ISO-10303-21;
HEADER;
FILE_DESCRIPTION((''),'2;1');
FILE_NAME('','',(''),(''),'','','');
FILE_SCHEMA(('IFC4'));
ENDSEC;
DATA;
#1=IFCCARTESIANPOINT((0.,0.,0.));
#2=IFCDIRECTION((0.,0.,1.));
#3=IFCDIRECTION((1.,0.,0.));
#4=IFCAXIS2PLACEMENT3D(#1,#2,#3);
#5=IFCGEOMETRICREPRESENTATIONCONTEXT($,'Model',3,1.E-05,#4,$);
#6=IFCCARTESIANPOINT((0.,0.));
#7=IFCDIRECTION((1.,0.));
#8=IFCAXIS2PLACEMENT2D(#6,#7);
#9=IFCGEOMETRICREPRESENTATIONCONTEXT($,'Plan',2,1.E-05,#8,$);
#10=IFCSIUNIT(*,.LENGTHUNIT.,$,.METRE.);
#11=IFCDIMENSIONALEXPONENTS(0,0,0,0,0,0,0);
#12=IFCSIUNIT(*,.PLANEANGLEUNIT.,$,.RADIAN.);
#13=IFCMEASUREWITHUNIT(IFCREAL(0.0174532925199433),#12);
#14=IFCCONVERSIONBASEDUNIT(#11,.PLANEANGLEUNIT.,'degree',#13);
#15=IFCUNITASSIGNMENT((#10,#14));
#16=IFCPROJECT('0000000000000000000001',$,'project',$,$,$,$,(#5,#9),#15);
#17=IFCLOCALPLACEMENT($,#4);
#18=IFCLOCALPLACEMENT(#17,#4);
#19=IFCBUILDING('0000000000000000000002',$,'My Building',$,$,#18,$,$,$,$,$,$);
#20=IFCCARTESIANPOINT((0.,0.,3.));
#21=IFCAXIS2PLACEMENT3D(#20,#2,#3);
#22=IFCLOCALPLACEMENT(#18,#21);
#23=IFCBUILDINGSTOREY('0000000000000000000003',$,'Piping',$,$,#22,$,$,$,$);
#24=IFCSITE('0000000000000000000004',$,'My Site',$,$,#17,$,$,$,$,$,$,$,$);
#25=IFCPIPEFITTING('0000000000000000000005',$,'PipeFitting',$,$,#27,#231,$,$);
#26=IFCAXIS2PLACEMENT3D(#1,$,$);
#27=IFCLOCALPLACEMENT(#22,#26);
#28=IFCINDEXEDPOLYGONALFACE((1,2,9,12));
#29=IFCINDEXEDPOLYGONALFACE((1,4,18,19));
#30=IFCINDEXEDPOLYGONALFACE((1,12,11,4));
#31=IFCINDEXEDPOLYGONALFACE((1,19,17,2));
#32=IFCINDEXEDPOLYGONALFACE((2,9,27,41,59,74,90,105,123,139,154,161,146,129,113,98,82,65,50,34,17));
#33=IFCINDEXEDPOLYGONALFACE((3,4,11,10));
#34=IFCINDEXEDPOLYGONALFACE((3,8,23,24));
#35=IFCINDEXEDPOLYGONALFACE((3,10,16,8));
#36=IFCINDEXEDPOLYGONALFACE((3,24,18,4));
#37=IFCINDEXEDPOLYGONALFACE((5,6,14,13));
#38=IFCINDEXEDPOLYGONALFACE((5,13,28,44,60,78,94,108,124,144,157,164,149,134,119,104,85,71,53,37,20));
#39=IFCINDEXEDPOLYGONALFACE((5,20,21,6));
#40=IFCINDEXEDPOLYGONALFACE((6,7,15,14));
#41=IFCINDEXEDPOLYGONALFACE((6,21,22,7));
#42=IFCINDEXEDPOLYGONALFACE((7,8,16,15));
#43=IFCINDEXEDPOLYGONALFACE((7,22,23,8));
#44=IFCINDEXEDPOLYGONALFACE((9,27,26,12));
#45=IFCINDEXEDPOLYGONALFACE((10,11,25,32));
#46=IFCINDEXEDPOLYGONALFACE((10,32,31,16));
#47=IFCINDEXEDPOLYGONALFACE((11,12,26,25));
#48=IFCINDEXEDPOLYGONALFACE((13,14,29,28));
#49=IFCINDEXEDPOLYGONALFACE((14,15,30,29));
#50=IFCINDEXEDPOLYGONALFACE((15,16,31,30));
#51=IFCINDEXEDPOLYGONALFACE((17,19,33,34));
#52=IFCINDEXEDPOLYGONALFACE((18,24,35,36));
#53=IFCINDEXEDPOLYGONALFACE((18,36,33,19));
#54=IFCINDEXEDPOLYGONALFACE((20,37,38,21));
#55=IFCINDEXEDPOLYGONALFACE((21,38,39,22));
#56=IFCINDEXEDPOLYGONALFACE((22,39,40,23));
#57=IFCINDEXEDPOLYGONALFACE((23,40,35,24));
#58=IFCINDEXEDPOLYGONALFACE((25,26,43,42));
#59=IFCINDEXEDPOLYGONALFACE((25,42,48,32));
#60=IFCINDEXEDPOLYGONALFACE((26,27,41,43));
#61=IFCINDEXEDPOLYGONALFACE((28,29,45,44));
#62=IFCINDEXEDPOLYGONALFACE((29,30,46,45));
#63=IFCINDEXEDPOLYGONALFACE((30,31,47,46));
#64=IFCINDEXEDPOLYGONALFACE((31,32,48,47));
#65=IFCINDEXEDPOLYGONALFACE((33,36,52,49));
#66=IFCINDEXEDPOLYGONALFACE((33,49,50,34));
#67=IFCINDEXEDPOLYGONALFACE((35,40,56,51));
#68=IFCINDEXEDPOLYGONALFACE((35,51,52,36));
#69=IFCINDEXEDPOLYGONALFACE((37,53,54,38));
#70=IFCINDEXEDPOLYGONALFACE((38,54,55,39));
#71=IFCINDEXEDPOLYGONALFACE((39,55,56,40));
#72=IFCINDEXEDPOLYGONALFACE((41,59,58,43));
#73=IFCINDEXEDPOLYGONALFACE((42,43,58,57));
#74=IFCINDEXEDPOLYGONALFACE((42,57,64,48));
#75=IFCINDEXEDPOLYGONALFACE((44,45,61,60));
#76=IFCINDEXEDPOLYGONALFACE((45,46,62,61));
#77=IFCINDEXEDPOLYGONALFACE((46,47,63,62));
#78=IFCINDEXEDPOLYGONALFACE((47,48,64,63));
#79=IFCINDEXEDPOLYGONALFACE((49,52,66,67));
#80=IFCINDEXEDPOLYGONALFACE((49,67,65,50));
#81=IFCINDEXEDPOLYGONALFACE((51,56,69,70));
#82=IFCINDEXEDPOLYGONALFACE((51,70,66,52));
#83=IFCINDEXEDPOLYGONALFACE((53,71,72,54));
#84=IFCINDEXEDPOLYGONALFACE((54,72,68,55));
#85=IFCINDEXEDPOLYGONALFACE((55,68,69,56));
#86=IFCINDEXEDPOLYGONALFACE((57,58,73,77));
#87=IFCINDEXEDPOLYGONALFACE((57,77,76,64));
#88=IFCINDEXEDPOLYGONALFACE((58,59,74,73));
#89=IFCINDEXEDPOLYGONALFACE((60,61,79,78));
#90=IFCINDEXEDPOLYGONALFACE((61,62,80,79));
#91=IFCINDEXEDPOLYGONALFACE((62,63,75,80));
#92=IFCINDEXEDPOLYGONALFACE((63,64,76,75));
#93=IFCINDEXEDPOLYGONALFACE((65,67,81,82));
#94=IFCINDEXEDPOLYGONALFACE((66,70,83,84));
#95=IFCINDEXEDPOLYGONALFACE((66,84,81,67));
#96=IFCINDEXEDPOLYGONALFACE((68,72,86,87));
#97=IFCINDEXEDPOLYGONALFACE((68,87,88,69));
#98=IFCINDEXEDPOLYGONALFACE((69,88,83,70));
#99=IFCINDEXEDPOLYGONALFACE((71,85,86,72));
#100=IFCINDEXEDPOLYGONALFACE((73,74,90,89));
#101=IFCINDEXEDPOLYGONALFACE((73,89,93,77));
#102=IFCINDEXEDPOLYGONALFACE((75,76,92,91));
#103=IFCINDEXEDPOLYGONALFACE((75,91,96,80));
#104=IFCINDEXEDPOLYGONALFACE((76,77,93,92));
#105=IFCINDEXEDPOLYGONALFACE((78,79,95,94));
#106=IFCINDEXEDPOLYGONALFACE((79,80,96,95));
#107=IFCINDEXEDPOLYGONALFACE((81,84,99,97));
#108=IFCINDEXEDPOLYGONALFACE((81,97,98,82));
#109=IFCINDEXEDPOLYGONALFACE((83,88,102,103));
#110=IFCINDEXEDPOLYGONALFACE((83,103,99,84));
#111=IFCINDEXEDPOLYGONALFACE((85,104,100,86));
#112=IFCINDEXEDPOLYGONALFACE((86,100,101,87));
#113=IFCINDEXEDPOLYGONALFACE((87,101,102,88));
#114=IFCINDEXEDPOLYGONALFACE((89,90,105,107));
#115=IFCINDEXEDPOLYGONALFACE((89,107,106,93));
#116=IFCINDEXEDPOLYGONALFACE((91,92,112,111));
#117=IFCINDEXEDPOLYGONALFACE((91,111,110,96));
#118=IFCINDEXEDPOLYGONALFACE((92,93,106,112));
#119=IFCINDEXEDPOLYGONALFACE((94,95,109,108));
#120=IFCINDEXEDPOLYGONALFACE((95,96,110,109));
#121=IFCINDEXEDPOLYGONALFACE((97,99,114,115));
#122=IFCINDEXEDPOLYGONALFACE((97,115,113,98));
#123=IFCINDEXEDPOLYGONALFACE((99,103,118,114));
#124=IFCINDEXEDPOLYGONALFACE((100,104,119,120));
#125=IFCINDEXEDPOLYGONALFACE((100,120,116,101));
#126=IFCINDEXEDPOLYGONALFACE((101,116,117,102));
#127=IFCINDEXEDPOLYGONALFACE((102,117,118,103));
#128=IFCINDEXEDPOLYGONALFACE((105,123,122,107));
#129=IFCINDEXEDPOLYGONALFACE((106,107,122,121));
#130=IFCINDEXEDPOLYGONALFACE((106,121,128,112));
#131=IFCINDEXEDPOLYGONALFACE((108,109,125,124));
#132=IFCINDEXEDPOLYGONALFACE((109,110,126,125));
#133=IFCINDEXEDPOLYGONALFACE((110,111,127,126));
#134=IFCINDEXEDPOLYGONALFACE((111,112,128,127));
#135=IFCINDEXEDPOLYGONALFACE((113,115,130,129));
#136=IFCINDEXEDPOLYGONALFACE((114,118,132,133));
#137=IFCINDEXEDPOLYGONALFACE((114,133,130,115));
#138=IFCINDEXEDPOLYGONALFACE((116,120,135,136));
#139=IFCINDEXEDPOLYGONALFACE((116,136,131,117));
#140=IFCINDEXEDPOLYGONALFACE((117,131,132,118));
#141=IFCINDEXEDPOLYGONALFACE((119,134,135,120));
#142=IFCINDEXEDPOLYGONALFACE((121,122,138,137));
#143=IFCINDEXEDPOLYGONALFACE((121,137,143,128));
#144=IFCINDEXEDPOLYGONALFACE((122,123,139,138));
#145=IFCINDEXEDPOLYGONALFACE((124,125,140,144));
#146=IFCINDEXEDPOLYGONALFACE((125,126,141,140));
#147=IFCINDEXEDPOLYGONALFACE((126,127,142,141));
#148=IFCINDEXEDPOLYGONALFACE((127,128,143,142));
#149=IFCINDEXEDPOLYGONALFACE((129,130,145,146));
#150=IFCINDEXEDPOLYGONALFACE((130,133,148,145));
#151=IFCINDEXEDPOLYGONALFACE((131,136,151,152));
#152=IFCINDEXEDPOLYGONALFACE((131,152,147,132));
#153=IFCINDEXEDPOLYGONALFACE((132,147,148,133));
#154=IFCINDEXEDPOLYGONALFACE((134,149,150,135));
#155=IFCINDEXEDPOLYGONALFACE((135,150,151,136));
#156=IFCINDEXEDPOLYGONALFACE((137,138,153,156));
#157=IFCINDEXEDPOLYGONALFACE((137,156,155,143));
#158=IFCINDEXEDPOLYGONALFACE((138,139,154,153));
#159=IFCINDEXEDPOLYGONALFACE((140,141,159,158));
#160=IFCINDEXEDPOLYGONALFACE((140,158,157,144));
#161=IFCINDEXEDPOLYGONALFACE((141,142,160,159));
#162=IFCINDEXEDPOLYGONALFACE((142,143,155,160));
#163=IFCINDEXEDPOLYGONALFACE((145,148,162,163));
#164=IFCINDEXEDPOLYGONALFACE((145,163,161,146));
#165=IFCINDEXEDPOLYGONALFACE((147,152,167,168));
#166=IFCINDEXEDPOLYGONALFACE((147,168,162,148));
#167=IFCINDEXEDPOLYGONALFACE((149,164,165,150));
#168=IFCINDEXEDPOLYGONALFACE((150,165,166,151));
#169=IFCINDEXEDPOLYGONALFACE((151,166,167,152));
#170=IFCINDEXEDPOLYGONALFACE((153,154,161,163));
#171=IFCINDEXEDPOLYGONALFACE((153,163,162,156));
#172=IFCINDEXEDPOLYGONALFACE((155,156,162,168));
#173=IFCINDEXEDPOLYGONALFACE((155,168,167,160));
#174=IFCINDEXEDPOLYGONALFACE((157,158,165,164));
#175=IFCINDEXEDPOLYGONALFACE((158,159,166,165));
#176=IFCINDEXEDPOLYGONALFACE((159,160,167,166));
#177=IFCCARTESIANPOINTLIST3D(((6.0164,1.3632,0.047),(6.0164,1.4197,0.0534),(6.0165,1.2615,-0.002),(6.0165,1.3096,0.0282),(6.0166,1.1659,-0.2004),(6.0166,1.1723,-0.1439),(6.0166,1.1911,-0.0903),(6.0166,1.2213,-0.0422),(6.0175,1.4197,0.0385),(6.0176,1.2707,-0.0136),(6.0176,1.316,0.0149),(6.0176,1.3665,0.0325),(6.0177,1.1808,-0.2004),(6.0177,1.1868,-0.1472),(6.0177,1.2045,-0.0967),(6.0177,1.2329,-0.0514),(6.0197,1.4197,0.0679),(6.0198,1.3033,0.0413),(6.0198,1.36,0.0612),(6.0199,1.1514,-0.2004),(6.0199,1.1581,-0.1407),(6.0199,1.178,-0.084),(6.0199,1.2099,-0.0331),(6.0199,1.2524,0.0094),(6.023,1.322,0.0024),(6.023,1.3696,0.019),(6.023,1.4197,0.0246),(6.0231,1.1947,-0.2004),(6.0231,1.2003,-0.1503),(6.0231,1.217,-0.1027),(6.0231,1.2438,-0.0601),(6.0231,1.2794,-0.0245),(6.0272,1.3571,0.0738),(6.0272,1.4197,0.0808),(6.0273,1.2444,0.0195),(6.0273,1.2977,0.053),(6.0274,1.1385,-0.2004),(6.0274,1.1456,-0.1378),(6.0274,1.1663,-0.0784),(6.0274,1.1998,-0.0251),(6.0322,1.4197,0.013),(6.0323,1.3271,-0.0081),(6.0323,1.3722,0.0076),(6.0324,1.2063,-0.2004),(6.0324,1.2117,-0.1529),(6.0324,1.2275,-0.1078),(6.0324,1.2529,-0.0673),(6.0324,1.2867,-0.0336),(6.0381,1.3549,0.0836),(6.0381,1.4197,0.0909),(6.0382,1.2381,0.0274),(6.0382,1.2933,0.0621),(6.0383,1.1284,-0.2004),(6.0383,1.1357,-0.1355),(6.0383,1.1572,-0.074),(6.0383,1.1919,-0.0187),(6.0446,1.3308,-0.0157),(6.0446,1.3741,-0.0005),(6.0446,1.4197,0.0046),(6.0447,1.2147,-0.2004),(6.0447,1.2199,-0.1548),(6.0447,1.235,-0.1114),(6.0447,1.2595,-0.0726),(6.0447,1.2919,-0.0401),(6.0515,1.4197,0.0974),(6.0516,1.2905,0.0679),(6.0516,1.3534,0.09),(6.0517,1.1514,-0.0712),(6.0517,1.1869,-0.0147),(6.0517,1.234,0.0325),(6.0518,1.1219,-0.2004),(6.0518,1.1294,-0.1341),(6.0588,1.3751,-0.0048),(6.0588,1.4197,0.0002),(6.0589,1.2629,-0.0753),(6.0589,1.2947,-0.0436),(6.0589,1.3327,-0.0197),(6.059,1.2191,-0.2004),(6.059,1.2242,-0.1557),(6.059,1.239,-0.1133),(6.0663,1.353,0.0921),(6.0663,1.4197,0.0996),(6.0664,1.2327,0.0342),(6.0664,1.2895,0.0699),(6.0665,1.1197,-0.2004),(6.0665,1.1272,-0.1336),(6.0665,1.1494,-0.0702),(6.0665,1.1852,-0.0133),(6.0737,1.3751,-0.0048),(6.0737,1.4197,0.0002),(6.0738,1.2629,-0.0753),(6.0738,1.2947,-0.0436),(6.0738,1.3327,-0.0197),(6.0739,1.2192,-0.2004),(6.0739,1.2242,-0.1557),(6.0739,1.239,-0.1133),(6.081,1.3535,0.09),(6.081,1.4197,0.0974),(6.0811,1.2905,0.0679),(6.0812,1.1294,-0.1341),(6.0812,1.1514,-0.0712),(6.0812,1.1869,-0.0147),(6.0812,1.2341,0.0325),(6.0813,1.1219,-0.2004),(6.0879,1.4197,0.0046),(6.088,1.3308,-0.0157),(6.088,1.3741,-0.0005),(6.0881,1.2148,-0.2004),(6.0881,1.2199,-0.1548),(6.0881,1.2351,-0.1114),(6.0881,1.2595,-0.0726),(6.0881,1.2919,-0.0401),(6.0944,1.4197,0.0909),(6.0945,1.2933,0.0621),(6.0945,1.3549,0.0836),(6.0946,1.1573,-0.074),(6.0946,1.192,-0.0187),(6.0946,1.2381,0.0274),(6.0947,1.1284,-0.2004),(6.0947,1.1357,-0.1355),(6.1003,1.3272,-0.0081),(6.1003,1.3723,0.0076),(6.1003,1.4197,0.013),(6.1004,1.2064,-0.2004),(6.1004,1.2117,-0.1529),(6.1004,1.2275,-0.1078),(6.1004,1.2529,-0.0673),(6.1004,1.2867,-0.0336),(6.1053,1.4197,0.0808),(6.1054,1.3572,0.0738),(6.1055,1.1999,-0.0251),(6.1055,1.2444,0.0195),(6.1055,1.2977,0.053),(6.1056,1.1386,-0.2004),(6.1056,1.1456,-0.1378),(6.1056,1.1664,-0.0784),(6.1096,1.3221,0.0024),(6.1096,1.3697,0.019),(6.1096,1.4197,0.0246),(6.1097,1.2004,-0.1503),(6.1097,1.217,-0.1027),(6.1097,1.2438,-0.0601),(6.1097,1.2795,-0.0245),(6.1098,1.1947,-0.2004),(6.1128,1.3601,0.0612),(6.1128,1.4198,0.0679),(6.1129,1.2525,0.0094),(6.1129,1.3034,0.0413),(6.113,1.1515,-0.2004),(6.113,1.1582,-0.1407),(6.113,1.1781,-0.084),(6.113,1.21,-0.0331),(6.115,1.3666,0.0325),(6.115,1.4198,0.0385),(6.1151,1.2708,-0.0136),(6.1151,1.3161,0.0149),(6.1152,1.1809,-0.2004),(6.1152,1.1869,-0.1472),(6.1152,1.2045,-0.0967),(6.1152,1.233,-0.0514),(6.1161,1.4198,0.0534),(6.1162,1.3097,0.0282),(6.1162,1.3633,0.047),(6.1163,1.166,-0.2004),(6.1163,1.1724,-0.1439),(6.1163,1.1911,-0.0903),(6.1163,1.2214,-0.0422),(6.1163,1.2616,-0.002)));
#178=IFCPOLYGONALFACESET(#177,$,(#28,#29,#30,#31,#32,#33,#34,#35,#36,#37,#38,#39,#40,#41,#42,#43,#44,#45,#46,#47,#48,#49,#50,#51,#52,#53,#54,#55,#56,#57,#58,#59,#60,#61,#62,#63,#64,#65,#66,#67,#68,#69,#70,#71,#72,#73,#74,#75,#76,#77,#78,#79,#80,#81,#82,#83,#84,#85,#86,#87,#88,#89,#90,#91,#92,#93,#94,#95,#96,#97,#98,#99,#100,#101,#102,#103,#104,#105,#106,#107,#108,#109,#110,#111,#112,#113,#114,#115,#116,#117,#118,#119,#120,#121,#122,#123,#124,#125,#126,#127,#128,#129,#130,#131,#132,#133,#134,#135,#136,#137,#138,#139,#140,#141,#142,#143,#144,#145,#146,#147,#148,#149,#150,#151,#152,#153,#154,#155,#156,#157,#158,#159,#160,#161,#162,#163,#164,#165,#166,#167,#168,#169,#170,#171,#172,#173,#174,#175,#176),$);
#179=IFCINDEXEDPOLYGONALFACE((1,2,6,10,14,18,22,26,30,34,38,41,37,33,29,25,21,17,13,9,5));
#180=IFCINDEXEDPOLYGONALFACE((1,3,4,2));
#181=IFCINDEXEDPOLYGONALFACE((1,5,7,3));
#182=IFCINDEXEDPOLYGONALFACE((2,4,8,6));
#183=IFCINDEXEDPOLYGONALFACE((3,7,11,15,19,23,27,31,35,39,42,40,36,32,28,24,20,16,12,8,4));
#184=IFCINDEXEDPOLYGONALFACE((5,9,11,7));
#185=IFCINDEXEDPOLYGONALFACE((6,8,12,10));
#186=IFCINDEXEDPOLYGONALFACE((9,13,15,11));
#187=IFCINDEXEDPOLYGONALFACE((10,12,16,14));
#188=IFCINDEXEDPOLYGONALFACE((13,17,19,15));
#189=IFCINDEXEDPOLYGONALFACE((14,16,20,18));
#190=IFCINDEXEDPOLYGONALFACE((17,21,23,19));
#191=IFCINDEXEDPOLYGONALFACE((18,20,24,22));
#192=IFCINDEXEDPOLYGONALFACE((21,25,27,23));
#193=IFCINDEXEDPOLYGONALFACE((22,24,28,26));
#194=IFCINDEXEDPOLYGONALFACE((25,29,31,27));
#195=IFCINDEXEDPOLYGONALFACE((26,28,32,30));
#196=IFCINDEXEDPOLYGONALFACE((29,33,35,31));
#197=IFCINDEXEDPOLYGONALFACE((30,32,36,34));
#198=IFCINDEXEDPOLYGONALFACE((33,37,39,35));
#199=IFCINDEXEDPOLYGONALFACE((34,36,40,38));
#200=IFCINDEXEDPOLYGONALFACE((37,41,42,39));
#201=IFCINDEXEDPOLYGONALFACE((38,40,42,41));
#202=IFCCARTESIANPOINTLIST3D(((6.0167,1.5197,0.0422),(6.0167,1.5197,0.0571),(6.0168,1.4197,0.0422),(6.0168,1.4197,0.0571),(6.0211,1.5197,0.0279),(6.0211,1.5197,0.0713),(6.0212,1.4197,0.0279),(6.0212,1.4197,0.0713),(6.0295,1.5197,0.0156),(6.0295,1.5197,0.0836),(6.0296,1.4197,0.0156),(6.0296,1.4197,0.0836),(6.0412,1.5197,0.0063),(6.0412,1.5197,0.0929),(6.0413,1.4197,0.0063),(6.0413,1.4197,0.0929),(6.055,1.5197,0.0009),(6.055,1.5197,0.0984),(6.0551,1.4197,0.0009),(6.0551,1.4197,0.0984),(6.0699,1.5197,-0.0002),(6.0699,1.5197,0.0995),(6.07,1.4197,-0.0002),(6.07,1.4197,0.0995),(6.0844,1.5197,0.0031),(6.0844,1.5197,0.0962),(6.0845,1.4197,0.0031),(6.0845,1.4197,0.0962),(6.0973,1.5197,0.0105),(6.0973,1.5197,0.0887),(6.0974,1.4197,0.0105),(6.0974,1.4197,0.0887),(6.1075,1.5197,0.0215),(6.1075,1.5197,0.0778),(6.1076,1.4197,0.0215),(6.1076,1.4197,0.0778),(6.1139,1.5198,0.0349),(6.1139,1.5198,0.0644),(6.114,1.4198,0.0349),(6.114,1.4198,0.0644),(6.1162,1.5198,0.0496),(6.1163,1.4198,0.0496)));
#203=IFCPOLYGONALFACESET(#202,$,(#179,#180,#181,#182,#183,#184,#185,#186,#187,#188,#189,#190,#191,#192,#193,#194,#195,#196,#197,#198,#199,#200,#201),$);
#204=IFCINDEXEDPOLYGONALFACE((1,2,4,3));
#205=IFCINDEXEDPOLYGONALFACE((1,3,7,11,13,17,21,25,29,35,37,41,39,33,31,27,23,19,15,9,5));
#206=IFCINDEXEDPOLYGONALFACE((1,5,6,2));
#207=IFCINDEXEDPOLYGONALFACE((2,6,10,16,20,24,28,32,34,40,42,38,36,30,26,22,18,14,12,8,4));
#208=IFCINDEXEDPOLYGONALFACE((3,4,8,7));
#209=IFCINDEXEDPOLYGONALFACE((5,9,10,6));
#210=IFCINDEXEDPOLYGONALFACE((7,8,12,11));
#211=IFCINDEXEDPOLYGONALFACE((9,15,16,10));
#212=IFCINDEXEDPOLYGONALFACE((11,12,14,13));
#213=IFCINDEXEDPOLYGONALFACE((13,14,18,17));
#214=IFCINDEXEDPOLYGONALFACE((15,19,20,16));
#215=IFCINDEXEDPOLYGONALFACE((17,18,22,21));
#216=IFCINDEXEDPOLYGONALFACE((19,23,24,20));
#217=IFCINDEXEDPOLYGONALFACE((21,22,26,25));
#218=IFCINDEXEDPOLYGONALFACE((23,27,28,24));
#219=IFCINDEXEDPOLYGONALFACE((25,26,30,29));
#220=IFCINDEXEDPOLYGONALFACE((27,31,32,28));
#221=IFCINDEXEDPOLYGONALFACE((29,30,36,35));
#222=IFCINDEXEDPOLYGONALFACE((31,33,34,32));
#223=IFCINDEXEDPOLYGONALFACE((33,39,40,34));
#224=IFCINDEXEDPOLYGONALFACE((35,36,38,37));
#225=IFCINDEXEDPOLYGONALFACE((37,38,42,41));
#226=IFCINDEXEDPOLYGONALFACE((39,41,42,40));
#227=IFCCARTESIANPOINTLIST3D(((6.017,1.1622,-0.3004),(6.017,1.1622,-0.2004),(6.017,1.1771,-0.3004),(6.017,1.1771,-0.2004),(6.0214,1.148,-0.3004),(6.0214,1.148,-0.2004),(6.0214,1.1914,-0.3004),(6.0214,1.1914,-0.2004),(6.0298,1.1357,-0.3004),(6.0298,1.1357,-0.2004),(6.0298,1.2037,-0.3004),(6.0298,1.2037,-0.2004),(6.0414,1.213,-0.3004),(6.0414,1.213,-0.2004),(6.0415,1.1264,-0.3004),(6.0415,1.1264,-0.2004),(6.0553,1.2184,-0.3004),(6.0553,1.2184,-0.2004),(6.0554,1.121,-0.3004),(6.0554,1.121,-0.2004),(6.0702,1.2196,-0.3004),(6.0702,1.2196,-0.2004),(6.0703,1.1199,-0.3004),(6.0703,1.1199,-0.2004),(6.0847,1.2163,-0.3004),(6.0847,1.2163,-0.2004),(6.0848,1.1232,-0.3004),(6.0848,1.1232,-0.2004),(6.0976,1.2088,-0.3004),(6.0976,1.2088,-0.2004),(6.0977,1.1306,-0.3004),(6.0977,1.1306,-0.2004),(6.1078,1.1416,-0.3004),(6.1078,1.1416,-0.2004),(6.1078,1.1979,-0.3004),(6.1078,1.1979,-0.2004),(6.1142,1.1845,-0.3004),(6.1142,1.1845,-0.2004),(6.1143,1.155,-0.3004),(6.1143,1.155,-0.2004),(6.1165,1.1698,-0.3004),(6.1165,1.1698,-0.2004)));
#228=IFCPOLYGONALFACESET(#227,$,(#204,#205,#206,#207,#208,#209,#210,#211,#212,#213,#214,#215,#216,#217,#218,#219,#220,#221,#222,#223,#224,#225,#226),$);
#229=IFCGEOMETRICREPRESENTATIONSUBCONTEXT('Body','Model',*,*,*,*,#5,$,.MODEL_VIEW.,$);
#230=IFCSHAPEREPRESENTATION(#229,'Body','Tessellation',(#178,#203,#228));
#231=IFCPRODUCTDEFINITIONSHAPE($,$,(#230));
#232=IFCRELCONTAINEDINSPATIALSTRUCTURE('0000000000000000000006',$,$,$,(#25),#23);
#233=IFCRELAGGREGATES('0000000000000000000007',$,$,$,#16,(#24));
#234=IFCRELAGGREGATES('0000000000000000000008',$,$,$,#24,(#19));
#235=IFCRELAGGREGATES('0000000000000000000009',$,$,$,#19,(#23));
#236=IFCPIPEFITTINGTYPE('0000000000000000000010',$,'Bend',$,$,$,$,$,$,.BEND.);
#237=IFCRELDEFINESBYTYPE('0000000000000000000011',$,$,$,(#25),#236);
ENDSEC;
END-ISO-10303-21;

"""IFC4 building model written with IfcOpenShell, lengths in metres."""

from ifc_helpers import new_model, entity, si_unit, converted_unit, frame, origin_with_axes, origin_2d_with_axis, place, context, subcontext, project, spatial, circle, extrude, source, transform, mapped, type_object, type_shapes, element, save


model = new_model("IFC4")

# Units and contexts
model_context = context("Model", 3, precision=1e-05, world=origin_with_axes())
plan_context = context("Plan", 2, precision=1e-05, world=origin_2d_with_axis())
body_context = subcontext(model_context, "Body", "Model", "MODEL_VIEW")
ifc_project = project(units=[si_unit("LENGTHUNIT", "METRE"), converted_unit("PLANEANGLEUNIT", "degree", entity("IfcReal", 0.0174532925199433), si_unit("PLANEANGLEUNIT", "RADIAN"), dimensions=[0, 0, 0, 0, 0, 0, 0])], contexts=[model_context, plan_context])

# Site, building, storey
site_placement = place(None, origin_with_axes())
site = spatial("IfcSite", under=ifc_project, at=site_placement, Name="My Site")
building_placement = place(site_placement, origin_with_axes())
building = spatial("IfcBuilding", under=site, at=building_placement, Name="My Building")
storey_placement = place(building_placement, frame((0.0, 0.0, 3.0), z_axis=(0.0, 0.0, 1.0), x_axis=(1.0, 0.0, 0.0)))
storey = spatial("IfcBuildingStorey", under=building, at=storey_placement, Name="Piping")

# Pipe fitting
pipe_fitting_type_1 = type_object("IfcPipeFittingType", Name="Bend", PredefinedType="BEND")
shared_shape = source(origin_with_axes(), body_context, "Body", "SolidModel", [
    entity("IfcSweptDiskSolid", entity("IfcIndexedPolyCurve", entity("IfcCartesianPointList3D", [[0.0, 0.0, 0.1], [0.0, -0.0732, 0.2768], [0.0, -0.25, 0.35]]), [entity("IfcArcIndex", [1, 2, 3])]), 0.05),
    extrude(circle(Radius=0.05), origin_with_axes(), (0.0, 0.0, 1.0), 0.1),
    extrude(circle(Radius=0.05), frame((0.0, -0.25, 0.35), z_axis=(0.0, -1.0, -0.000001), x_axis=(1.0, 0.0, 0.0)), (0.0, 0.0, 1.0), 0.1),
])
type_shapes(pipe_fitting_type_1, [shared_shape])
for number, where, z_axis, x_axis, name in (
    (1, (6.0662, 1.5197, 0.0496), (0.000872, -1.0, 0.000001), (1.0, 0.000872, 0.0), "PipeFitting"),
):
    element("IfcPipeFitting", number, at=place(storey_placement, frame(where, z_axis=z_axis, x_axis=x_axis)), inside=storey, type_object=pipe_fitting_type_1, Name=name, context=body_context, shape_type="MappedRepresentation", body=[
        mapped(shared_shape, transform((0.0, 0.0, 0.0), x_axis=(1.0, 0.0, 0.0), y_axis=(0.0, 1.0, 0.0), z_axis=(0.0, 0.0, 1.0), scale=1.0)),
    ])

save(model, "model.ifc")
